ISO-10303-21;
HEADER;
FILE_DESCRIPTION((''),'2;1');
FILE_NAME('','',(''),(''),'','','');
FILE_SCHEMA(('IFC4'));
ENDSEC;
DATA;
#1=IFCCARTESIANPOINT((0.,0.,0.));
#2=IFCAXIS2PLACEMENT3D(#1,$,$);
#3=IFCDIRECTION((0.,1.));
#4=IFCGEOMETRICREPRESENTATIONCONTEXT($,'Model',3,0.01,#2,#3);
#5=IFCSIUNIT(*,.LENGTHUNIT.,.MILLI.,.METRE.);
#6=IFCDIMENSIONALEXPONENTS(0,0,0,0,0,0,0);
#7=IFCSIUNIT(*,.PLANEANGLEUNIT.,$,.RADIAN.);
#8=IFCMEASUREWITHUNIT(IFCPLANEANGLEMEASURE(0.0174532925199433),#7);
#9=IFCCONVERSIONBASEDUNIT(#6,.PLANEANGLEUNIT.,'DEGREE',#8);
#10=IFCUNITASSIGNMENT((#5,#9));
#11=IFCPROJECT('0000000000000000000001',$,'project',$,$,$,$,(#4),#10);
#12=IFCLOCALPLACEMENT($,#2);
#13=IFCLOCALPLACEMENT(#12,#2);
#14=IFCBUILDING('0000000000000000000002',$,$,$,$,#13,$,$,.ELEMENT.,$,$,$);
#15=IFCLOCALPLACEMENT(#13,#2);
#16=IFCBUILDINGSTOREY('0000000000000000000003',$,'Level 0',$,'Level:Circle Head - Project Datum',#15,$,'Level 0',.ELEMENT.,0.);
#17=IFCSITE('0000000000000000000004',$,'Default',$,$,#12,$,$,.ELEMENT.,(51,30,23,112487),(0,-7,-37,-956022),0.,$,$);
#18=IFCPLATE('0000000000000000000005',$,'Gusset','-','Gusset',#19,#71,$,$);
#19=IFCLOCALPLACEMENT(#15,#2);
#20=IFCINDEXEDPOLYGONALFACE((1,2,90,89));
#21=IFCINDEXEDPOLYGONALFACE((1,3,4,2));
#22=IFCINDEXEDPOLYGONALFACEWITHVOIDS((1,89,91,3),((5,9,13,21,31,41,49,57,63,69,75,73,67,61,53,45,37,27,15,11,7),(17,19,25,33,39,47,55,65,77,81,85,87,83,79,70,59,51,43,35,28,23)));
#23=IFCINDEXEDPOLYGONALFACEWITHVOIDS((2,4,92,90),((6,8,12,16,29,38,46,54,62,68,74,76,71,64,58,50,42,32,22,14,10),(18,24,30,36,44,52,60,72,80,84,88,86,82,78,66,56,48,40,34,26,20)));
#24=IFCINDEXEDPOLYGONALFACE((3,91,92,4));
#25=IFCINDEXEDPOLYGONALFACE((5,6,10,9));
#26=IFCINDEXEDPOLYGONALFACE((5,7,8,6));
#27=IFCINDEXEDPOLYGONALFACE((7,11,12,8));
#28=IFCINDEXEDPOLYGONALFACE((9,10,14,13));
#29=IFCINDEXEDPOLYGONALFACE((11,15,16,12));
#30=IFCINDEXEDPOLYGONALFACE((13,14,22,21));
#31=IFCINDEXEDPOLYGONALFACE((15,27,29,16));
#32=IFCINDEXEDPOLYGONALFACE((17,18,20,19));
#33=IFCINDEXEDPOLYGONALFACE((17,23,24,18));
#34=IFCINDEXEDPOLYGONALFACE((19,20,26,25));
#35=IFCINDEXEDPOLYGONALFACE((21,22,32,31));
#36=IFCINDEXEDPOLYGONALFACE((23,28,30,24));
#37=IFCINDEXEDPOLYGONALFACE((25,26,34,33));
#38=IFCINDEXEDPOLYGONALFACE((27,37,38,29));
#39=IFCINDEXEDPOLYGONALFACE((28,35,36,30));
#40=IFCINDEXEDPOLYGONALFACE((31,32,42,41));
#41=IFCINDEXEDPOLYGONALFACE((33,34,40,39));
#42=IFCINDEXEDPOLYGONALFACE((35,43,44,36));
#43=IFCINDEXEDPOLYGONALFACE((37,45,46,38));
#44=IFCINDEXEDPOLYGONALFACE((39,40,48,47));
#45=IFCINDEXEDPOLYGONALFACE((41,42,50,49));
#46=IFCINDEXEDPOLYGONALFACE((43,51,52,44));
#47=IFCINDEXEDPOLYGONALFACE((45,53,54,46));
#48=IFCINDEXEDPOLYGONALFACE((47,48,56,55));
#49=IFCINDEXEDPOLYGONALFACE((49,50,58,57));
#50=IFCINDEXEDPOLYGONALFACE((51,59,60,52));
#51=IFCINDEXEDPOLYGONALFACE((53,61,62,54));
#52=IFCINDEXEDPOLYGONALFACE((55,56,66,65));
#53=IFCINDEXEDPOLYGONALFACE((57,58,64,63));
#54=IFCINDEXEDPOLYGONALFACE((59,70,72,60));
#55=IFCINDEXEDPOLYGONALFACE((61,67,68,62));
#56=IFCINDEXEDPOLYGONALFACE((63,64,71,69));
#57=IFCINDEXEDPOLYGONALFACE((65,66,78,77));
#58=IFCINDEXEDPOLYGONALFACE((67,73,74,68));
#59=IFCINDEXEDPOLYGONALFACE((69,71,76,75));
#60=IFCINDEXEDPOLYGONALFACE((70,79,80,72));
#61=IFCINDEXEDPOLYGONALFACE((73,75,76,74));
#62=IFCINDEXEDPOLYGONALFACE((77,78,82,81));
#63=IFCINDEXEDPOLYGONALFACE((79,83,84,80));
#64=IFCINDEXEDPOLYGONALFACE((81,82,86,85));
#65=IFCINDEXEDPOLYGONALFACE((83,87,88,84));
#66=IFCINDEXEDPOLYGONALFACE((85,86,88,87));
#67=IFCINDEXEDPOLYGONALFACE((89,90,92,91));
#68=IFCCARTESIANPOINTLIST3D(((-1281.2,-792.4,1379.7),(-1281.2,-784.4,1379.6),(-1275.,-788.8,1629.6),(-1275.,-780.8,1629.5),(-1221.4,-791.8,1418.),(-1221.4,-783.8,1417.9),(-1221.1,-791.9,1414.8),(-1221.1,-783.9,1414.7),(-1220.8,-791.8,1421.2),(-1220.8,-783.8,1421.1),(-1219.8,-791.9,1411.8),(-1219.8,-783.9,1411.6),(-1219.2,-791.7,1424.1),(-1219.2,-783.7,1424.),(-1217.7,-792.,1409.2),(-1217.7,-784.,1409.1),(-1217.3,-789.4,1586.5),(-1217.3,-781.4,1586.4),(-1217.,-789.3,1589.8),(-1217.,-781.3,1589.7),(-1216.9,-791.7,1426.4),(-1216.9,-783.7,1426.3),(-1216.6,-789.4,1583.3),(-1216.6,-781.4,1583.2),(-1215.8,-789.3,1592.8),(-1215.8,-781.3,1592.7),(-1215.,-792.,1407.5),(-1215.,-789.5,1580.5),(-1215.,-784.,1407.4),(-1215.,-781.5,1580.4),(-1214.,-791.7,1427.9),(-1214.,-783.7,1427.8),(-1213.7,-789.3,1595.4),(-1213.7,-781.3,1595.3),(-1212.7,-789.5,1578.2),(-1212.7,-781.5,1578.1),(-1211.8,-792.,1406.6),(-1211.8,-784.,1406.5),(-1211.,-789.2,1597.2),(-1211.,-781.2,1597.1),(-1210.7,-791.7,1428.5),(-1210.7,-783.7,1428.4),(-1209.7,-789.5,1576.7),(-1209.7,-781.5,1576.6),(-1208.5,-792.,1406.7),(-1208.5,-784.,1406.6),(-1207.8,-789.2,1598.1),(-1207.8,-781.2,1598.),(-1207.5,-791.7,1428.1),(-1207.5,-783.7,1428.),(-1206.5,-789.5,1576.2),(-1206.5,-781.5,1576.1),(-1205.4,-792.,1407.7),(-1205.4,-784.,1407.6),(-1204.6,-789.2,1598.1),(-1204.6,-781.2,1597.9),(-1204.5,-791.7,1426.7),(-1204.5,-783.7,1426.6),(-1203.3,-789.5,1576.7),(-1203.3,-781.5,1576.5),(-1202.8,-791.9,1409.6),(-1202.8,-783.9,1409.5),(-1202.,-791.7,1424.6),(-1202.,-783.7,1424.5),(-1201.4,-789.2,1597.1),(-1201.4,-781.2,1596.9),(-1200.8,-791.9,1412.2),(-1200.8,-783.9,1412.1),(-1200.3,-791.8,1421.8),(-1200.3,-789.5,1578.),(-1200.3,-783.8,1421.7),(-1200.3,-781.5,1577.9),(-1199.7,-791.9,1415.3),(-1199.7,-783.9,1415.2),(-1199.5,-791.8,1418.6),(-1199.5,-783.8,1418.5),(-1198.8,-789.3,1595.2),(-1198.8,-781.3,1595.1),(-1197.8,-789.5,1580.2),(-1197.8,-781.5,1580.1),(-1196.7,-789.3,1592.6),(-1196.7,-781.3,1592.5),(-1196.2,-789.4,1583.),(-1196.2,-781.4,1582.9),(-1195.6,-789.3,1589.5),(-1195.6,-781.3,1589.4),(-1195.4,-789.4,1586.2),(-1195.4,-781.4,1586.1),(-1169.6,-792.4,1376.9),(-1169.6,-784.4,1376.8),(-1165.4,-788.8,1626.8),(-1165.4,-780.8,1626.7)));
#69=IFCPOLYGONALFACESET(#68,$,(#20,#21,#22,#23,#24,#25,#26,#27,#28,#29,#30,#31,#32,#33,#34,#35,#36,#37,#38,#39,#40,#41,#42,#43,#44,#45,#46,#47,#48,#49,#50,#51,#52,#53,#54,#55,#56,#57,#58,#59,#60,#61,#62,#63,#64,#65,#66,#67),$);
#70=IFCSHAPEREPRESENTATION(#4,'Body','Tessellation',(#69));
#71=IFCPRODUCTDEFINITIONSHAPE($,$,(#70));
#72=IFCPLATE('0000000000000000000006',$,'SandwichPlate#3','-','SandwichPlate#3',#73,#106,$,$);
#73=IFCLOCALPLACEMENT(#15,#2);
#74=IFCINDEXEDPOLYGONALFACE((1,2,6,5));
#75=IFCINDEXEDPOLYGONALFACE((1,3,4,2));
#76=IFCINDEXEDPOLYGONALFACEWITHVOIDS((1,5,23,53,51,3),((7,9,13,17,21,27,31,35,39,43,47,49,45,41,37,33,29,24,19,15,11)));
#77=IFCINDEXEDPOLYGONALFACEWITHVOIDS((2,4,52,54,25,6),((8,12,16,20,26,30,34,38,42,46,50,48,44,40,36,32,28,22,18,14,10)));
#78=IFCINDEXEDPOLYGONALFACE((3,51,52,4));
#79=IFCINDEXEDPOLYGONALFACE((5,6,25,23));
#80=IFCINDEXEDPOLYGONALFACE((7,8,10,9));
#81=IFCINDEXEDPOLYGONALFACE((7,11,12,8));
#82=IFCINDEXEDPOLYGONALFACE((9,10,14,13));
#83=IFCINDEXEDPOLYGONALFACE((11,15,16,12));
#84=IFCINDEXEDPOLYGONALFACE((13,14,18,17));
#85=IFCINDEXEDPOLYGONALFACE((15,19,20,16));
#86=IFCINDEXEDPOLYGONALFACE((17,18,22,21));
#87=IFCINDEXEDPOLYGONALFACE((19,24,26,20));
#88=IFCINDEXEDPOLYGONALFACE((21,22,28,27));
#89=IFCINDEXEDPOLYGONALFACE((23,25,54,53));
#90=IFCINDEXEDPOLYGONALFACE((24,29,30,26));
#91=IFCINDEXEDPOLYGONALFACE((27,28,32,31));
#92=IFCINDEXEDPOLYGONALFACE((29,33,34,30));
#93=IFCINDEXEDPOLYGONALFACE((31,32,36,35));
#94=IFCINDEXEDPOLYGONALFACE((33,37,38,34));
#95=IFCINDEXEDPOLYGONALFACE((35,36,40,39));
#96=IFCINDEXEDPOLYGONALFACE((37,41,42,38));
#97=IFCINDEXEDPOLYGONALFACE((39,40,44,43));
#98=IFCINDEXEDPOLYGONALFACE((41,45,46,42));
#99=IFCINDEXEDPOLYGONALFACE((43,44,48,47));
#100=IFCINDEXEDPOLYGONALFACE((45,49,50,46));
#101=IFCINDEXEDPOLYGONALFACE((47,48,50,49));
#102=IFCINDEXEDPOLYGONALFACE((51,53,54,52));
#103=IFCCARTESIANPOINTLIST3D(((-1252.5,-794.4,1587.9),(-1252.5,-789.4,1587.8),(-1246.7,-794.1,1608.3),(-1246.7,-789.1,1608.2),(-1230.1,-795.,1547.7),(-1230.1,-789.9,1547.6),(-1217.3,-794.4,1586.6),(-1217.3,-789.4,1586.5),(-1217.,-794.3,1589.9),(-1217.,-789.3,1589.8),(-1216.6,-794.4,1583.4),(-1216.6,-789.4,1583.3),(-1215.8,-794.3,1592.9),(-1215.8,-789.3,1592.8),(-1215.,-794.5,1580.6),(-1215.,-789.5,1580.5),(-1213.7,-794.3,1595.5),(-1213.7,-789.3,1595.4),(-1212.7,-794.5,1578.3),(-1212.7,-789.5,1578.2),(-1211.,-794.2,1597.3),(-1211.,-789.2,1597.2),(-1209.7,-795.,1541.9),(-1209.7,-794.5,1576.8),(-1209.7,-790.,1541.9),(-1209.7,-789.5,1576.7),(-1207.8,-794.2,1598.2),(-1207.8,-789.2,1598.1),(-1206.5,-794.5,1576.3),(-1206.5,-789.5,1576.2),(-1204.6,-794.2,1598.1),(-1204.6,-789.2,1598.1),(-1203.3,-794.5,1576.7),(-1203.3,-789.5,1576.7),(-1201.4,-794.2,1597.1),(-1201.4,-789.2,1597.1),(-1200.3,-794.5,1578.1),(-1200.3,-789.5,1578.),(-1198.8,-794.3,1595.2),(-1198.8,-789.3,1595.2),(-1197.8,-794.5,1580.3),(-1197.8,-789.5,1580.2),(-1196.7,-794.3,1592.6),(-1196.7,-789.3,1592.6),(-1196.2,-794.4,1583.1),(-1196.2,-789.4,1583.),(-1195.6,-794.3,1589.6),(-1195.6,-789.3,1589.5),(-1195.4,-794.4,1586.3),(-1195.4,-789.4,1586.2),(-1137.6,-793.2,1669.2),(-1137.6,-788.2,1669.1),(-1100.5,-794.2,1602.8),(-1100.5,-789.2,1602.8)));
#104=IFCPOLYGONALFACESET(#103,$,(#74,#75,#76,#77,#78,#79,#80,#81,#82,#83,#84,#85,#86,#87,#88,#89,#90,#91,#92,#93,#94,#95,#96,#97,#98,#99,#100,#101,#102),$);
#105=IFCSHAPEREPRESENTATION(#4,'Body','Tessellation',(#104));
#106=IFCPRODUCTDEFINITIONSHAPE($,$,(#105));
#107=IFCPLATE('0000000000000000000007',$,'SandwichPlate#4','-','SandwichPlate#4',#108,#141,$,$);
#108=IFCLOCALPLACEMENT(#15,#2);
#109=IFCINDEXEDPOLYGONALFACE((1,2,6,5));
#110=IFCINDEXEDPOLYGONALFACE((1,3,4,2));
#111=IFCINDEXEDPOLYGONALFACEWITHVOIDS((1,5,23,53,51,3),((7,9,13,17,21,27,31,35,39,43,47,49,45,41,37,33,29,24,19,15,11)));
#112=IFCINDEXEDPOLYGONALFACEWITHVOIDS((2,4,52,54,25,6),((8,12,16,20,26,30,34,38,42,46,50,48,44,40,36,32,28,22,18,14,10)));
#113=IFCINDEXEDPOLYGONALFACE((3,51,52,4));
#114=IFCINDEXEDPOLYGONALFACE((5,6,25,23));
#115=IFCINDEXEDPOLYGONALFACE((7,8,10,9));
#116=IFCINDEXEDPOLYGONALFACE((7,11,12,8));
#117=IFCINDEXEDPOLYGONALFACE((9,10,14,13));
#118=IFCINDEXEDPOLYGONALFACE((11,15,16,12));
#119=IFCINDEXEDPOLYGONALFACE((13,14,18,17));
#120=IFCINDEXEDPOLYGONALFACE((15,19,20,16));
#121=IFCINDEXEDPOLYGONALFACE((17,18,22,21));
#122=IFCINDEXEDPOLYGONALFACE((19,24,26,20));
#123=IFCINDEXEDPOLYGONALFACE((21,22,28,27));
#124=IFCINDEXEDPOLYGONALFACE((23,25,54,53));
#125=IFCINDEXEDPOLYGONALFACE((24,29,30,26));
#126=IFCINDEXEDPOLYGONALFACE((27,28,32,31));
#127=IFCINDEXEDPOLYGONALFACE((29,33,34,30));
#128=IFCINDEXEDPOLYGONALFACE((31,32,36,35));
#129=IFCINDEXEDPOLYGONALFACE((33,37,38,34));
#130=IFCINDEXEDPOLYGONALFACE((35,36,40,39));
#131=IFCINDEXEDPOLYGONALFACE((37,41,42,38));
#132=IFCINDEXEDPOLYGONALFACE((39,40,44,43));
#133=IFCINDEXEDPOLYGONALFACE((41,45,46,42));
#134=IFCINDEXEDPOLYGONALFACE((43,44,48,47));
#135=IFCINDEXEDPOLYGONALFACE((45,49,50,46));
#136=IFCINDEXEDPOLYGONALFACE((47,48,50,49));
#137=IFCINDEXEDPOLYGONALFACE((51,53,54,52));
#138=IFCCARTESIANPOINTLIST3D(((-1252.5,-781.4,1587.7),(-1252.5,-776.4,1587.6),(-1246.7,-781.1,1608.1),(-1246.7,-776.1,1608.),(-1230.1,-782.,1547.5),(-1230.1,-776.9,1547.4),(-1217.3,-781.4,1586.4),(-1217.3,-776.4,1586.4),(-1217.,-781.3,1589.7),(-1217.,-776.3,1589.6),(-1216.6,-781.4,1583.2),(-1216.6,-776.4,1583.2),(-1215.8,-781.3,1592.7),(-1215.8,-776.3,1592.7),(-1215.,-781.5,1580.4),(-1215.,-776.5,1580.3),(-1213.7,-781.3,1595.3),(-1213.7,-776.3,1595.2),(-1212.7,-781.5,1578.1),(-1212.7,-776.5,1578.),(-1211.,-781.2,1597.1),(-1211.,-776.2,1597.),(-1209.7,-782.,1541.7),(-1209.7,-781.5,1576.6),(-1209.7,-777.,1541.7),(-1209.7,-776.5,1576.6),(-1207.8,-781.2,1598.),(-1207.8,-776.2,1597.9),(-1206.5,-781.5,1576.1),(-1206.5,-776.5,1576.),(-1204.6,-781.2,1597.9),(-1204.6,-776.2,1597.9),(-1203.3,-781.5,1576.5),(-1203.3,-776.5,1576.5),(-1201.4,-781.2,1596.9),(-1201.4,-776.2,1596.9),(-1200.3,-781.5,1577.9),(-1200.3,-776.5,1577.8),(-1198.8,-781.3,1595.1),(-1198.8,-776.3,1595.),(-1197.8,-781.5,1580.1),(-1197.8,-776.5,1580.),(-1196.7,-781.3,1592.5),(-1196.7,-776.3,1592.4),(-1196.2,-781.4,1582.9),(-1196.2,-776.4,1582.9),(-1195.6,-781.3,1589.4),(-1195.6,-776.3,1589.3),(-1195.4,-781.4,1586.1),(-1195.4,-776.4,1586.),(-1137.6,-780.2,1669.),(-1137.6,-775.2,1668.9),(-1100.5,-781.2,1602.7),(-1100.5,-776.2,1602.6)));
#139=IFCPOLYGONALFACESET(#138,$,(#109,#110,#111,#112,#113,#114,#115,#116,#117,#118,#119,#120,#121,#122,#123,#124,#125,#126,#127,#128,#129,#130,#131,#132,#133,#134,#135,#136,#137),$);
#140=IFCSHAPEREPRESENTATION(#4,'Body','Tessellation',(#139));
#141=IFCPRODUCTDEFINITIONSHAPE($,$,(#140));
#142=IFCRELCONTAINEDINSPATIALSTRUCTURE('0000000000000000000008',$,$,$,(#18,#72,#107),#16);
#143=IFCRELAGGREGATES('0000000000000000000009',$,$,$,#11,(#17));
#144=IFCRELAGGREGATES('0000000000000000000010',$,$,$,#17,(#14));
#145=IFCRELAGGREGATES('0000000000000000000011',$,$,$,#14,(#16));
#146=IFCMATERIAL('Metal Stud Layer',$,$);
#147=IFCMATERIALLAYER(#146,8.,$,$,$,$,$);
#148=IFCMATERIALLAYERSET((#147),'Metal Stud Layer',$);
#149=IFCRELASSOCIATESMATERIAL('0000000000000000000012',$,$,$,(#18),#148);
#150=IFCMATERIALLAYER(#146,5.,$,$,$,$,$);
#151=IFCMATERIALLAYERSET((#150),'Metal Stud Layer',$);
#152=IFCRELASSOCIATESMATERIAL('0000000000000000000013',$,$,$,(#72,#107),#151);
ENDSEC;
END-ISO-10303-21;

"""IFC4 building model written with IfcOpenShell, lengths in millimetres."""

from ifc_helpers import new_model, entity, si_unit, converted_unit, direction, frame, origin, origin_with_axes, origin_2d_with_axis, place, context, project, spatial, polyline, circle, outline, extrude, material, layer, layer_set, element, save


model = new_model("IFC4")

# Units and contexts
model_context = context("Model", 3, precision=0.01, world=origin(), true_north=direction((0.0, 1.0)))
ifc_project = project(units=[si_unit("LENGTHUNIT", "METRE", prefix="MILLI"), converted_unit("PLANEANGLEUNIT", "DEGREE", entity("IfcPlaneAngleMeasure", 0.0174532925199433), si_unit("PLANEANGLEUNIT", "RADIAN"), dimensions=[0, 0, 0, 0, 0, 0, 0])], contexts=[model_context])

# Site, building, storey
site_placement = place(None, origin())
site = spatial("IfcSite", under=ifc_project, at=site_placement, Name="Default", CompositionType="ELEMENT", RefLatitude=(51, 30, 23, 112487), RefLongitude=(0, -7, -37, -956022), RefElevation=0.0)
building_placement = place(site_placement, origin())
building = spatial("IfcBuilding", under=site, at=building_placement, CompositionType="ELEMENT")
storey_placement = place(building_placement, origin())
storey = spatial("IfcBuildingStorey", under=building, at=storey_placement, Name="Level 0", ObjectType="Level:Circle Head - Project Datum", LongName="Level 0", CompositionType="ELEMENT", Elevation=0.0)

# Plates, openings
ifc_material_1 = material(Name="Metal Stud Layer")
ifc_layer_1 = layer(ifc_material_1, 8.0)
ifc_layer_set_1 = layer_set([ifc_layer_1], Name="Metal Stud Layer")
plate_1_placement = place(storey_placement, frame((-1272.8, -780.8, 1628.9), z_axis=(0.0, -0.999896, 0.014432), x_axis=(-0.02499, -0.014428, -0.999584)))
plate_1 = element("IfcPlate", 1, at=plate_1_placement, inside=storey, material=ifc_layer_set_1, Name="Gusset", Description="-", ObjectType="Gusset", context=model_context, shape_type="SweptSolid", body=[
    extrude(outline(polyline([(-0.5, -2.2), (249.5, -2.2), (249.5, 109.5), (-0.5, 107.4), (-0.5, -2.2)])), origin_with_axes(), (0.0, 0.0, 1.0), 8.0),
])
opening_1_placement = place(plate_1_placement, frame((40.2, 67.5, 8.5), z_axis=(0.0, 0.0, -1.0), x_axis=(-0.509073, 0.860723, 0.0)))
element("IfcOpeningElement", 2, at=opening_1_placement, cuts=plate_1, ObjectType="Opening", context=model_context, shape_type="SweptSolid", body=[
    extrude(circle(Radius=11.0, at=origin_2d_with_axis()), origin(), (0.0, 0.0, 1.0), 9.0),
])
opening_2_placement = place(plate_1_placement, frame((209.9, 67.6, 8.5), z_axis=(0.0, 0.0, -1.0), x_axis=(0.455108, 0.890436, 0.0)))
element("IfcOpeningElement", 3, at=opening_2_placement, cuts=plate_1, ObjectType="Opening", context=model_context, shape_type="SweptSolid", body=[
    extrude(circle(Radius=11.0, at=origin_2d_with_axis()), origin(), (0.0, 0.0, 1.0), 9.0),
])
ifc_layer_2 = layer(ifc_material_1, 5.0)
ifc_layer_set_2 = layer_set([ifc_layer_2], Name="Metal Stud Layer")
plate_2_placement = place(storey_placement, frame((-1222.8, -795.1, 1534.6), z_axis=(0.0, 0.999896, -0.014432), x_axis=(-0.487405, 0.012602, 0.873085)))
plate_2 = element("IfcPlate", 4, at=plate_2_placement, inside=storey, material=ifc_layer_set_2, Name="SandwichPlate#3", Description="-", ObjectType="SandwichPlate#3", context=model_context, shape_type="SweptSolid", body=[
    extrude(outline(polyline([(0.0, 0.0), (76.0, 0.0), (76.0, 140.0), (0.0, 140.0), (0.0, 0.0)])), origin_with_axes(), (0.0, 0.0, 1.0), 5.0),
])
opening_3_placement = place(plate_2_placement, frame((0.0, 0.0, 0.0), z_axis=(0.0, 0.0, 1.0), x_axis=(1.0, 0.0, 0.0)))
element("IfcOpeningElement", 5, at=opening_3_placement, cuts=plate_2, ObjectType="Opening", context=model_context, shape_type="SweptSolid", body=[
    extrude(outline(polyline([(0.0, 0.0), (15.0, 0.0), (0.0, 15.0), (0.0, 0.0)])), origin(), (0.0, 0.0, 1.0), 5.0),
])
opening_4_placement = place(plate_2_placement, frame((0.0, 0.0, 0.0), z_axis=(0.0, 0.0, 1.0), x_axis=(1.0, 0.0, 0.0)))
element("IfcOpeningElement", 6, at=opening_4_placement, cuts=plate_2, ObjectType="Opening", context=model_context, shape_type="SweptSolid", body=[
    extrude(outline(polyline([(76.0, 0.0), (76.0, 15.0), (61.0, 0.0), (76.0, 0.0)])), origin(), (0.0, 0.0, 1.0), 5.0),
])
opening_5_placement = place(plate_2_placement, frame((38.0, 40.0, -0.5), z_axis=(0.0, 0.0, 1.0), x_axis=(0.0, 1.0, 0.0)))
element("IfcOpeningElement", 7, at=opening_5_placement, cuts=plate_2, ObjectType="Opening", context=model_context, shape_type="SweptSolid", body=[
    extrude(circle(Radius=11.0, at=origin_2d_with_axis()), origin(), (0.0, 0.0, 1.0), 6.0),
])
plate_3_placement = place(storey_placement, frame((-1222.8, -782.1, 1534.4), z_axis=(0.0, 0.999896, -0.014432), x_axis=(-0.487405, 0.012602, 0.873085)))
plate_3 = element("IfcPlate", 8, at=plate_3_placement, inside=storey, material=ifc_layer_set_2, Name="SandwichPlate#4", Description="-", ObjectType="SandwichPlate#4", context=model_context, shape_type="SweptSolid", body=[
    extrude(outline(polyline([(0.0, 0.0), (76.0, 0.0), (76.0, 140.0), (0.0, 140.0), (0.0, 0.0)])), origin_with_axes(), (0.0, 0.0, 1.0), 5.0),
])
opening_6_placement = place(plate_3_placement, frame((0.0, 0.0, 0.0), z_axis=(0.0, 0.0, 1.0), x_axis=(1.0, 0.0, 0.0)))
element("IfcOpeningElement", 9, at=opening_6_placement, cuts=plate_3, ObjectType="Opening", context=model_context, shape_type="SweptSolid", body=[
    extrude(outline(polyline([(0.0, 0.0), (15.0, 0.0), (0.0, 15.0), (0.0, 0.0)])), origin(), (0.0, 0.0, 1.0), 5.0),
])
opening_7_placement = place(plate_3_placement, frame((0.0, 0.0, 0.0), z_axis=(0.0, 0.0, 1.0), x_axis=(1.0, 0.0, 0.0)))
element("IfcOpeningElement", 10, at=opening_7_placement, cuts=plate_3, ObjectType="Opening", context=model_context, shape_type="SweptSolid", body=[
    extrude(outline(polyline([(76.0, 0.0), (76.0, 15.0), (61.0, 0.0), (76.0, 0.0)])), origin(), (0.0, 0.0, 1.0), 5.0),
])
opening_8_placement = place(plate_3_placement, frame((38.0, 40.0, -0.5), z_axis=(0.0, 0.0, 1.0), x_axis=(0.0, 1.0, 0.0)))
element("IfcOpeningElement", 11, at=opening_8_placement, cuts=plate_3, ObjectType="Opening", context=model_context, shape_type="SweptSolid", body=[
    extrude(circle(Radius=11.0, at=origin_2d_with_axis()), origin(), (0.0, 0.0, 1.0), 6.0),
])

save(model, "model.ifc")
